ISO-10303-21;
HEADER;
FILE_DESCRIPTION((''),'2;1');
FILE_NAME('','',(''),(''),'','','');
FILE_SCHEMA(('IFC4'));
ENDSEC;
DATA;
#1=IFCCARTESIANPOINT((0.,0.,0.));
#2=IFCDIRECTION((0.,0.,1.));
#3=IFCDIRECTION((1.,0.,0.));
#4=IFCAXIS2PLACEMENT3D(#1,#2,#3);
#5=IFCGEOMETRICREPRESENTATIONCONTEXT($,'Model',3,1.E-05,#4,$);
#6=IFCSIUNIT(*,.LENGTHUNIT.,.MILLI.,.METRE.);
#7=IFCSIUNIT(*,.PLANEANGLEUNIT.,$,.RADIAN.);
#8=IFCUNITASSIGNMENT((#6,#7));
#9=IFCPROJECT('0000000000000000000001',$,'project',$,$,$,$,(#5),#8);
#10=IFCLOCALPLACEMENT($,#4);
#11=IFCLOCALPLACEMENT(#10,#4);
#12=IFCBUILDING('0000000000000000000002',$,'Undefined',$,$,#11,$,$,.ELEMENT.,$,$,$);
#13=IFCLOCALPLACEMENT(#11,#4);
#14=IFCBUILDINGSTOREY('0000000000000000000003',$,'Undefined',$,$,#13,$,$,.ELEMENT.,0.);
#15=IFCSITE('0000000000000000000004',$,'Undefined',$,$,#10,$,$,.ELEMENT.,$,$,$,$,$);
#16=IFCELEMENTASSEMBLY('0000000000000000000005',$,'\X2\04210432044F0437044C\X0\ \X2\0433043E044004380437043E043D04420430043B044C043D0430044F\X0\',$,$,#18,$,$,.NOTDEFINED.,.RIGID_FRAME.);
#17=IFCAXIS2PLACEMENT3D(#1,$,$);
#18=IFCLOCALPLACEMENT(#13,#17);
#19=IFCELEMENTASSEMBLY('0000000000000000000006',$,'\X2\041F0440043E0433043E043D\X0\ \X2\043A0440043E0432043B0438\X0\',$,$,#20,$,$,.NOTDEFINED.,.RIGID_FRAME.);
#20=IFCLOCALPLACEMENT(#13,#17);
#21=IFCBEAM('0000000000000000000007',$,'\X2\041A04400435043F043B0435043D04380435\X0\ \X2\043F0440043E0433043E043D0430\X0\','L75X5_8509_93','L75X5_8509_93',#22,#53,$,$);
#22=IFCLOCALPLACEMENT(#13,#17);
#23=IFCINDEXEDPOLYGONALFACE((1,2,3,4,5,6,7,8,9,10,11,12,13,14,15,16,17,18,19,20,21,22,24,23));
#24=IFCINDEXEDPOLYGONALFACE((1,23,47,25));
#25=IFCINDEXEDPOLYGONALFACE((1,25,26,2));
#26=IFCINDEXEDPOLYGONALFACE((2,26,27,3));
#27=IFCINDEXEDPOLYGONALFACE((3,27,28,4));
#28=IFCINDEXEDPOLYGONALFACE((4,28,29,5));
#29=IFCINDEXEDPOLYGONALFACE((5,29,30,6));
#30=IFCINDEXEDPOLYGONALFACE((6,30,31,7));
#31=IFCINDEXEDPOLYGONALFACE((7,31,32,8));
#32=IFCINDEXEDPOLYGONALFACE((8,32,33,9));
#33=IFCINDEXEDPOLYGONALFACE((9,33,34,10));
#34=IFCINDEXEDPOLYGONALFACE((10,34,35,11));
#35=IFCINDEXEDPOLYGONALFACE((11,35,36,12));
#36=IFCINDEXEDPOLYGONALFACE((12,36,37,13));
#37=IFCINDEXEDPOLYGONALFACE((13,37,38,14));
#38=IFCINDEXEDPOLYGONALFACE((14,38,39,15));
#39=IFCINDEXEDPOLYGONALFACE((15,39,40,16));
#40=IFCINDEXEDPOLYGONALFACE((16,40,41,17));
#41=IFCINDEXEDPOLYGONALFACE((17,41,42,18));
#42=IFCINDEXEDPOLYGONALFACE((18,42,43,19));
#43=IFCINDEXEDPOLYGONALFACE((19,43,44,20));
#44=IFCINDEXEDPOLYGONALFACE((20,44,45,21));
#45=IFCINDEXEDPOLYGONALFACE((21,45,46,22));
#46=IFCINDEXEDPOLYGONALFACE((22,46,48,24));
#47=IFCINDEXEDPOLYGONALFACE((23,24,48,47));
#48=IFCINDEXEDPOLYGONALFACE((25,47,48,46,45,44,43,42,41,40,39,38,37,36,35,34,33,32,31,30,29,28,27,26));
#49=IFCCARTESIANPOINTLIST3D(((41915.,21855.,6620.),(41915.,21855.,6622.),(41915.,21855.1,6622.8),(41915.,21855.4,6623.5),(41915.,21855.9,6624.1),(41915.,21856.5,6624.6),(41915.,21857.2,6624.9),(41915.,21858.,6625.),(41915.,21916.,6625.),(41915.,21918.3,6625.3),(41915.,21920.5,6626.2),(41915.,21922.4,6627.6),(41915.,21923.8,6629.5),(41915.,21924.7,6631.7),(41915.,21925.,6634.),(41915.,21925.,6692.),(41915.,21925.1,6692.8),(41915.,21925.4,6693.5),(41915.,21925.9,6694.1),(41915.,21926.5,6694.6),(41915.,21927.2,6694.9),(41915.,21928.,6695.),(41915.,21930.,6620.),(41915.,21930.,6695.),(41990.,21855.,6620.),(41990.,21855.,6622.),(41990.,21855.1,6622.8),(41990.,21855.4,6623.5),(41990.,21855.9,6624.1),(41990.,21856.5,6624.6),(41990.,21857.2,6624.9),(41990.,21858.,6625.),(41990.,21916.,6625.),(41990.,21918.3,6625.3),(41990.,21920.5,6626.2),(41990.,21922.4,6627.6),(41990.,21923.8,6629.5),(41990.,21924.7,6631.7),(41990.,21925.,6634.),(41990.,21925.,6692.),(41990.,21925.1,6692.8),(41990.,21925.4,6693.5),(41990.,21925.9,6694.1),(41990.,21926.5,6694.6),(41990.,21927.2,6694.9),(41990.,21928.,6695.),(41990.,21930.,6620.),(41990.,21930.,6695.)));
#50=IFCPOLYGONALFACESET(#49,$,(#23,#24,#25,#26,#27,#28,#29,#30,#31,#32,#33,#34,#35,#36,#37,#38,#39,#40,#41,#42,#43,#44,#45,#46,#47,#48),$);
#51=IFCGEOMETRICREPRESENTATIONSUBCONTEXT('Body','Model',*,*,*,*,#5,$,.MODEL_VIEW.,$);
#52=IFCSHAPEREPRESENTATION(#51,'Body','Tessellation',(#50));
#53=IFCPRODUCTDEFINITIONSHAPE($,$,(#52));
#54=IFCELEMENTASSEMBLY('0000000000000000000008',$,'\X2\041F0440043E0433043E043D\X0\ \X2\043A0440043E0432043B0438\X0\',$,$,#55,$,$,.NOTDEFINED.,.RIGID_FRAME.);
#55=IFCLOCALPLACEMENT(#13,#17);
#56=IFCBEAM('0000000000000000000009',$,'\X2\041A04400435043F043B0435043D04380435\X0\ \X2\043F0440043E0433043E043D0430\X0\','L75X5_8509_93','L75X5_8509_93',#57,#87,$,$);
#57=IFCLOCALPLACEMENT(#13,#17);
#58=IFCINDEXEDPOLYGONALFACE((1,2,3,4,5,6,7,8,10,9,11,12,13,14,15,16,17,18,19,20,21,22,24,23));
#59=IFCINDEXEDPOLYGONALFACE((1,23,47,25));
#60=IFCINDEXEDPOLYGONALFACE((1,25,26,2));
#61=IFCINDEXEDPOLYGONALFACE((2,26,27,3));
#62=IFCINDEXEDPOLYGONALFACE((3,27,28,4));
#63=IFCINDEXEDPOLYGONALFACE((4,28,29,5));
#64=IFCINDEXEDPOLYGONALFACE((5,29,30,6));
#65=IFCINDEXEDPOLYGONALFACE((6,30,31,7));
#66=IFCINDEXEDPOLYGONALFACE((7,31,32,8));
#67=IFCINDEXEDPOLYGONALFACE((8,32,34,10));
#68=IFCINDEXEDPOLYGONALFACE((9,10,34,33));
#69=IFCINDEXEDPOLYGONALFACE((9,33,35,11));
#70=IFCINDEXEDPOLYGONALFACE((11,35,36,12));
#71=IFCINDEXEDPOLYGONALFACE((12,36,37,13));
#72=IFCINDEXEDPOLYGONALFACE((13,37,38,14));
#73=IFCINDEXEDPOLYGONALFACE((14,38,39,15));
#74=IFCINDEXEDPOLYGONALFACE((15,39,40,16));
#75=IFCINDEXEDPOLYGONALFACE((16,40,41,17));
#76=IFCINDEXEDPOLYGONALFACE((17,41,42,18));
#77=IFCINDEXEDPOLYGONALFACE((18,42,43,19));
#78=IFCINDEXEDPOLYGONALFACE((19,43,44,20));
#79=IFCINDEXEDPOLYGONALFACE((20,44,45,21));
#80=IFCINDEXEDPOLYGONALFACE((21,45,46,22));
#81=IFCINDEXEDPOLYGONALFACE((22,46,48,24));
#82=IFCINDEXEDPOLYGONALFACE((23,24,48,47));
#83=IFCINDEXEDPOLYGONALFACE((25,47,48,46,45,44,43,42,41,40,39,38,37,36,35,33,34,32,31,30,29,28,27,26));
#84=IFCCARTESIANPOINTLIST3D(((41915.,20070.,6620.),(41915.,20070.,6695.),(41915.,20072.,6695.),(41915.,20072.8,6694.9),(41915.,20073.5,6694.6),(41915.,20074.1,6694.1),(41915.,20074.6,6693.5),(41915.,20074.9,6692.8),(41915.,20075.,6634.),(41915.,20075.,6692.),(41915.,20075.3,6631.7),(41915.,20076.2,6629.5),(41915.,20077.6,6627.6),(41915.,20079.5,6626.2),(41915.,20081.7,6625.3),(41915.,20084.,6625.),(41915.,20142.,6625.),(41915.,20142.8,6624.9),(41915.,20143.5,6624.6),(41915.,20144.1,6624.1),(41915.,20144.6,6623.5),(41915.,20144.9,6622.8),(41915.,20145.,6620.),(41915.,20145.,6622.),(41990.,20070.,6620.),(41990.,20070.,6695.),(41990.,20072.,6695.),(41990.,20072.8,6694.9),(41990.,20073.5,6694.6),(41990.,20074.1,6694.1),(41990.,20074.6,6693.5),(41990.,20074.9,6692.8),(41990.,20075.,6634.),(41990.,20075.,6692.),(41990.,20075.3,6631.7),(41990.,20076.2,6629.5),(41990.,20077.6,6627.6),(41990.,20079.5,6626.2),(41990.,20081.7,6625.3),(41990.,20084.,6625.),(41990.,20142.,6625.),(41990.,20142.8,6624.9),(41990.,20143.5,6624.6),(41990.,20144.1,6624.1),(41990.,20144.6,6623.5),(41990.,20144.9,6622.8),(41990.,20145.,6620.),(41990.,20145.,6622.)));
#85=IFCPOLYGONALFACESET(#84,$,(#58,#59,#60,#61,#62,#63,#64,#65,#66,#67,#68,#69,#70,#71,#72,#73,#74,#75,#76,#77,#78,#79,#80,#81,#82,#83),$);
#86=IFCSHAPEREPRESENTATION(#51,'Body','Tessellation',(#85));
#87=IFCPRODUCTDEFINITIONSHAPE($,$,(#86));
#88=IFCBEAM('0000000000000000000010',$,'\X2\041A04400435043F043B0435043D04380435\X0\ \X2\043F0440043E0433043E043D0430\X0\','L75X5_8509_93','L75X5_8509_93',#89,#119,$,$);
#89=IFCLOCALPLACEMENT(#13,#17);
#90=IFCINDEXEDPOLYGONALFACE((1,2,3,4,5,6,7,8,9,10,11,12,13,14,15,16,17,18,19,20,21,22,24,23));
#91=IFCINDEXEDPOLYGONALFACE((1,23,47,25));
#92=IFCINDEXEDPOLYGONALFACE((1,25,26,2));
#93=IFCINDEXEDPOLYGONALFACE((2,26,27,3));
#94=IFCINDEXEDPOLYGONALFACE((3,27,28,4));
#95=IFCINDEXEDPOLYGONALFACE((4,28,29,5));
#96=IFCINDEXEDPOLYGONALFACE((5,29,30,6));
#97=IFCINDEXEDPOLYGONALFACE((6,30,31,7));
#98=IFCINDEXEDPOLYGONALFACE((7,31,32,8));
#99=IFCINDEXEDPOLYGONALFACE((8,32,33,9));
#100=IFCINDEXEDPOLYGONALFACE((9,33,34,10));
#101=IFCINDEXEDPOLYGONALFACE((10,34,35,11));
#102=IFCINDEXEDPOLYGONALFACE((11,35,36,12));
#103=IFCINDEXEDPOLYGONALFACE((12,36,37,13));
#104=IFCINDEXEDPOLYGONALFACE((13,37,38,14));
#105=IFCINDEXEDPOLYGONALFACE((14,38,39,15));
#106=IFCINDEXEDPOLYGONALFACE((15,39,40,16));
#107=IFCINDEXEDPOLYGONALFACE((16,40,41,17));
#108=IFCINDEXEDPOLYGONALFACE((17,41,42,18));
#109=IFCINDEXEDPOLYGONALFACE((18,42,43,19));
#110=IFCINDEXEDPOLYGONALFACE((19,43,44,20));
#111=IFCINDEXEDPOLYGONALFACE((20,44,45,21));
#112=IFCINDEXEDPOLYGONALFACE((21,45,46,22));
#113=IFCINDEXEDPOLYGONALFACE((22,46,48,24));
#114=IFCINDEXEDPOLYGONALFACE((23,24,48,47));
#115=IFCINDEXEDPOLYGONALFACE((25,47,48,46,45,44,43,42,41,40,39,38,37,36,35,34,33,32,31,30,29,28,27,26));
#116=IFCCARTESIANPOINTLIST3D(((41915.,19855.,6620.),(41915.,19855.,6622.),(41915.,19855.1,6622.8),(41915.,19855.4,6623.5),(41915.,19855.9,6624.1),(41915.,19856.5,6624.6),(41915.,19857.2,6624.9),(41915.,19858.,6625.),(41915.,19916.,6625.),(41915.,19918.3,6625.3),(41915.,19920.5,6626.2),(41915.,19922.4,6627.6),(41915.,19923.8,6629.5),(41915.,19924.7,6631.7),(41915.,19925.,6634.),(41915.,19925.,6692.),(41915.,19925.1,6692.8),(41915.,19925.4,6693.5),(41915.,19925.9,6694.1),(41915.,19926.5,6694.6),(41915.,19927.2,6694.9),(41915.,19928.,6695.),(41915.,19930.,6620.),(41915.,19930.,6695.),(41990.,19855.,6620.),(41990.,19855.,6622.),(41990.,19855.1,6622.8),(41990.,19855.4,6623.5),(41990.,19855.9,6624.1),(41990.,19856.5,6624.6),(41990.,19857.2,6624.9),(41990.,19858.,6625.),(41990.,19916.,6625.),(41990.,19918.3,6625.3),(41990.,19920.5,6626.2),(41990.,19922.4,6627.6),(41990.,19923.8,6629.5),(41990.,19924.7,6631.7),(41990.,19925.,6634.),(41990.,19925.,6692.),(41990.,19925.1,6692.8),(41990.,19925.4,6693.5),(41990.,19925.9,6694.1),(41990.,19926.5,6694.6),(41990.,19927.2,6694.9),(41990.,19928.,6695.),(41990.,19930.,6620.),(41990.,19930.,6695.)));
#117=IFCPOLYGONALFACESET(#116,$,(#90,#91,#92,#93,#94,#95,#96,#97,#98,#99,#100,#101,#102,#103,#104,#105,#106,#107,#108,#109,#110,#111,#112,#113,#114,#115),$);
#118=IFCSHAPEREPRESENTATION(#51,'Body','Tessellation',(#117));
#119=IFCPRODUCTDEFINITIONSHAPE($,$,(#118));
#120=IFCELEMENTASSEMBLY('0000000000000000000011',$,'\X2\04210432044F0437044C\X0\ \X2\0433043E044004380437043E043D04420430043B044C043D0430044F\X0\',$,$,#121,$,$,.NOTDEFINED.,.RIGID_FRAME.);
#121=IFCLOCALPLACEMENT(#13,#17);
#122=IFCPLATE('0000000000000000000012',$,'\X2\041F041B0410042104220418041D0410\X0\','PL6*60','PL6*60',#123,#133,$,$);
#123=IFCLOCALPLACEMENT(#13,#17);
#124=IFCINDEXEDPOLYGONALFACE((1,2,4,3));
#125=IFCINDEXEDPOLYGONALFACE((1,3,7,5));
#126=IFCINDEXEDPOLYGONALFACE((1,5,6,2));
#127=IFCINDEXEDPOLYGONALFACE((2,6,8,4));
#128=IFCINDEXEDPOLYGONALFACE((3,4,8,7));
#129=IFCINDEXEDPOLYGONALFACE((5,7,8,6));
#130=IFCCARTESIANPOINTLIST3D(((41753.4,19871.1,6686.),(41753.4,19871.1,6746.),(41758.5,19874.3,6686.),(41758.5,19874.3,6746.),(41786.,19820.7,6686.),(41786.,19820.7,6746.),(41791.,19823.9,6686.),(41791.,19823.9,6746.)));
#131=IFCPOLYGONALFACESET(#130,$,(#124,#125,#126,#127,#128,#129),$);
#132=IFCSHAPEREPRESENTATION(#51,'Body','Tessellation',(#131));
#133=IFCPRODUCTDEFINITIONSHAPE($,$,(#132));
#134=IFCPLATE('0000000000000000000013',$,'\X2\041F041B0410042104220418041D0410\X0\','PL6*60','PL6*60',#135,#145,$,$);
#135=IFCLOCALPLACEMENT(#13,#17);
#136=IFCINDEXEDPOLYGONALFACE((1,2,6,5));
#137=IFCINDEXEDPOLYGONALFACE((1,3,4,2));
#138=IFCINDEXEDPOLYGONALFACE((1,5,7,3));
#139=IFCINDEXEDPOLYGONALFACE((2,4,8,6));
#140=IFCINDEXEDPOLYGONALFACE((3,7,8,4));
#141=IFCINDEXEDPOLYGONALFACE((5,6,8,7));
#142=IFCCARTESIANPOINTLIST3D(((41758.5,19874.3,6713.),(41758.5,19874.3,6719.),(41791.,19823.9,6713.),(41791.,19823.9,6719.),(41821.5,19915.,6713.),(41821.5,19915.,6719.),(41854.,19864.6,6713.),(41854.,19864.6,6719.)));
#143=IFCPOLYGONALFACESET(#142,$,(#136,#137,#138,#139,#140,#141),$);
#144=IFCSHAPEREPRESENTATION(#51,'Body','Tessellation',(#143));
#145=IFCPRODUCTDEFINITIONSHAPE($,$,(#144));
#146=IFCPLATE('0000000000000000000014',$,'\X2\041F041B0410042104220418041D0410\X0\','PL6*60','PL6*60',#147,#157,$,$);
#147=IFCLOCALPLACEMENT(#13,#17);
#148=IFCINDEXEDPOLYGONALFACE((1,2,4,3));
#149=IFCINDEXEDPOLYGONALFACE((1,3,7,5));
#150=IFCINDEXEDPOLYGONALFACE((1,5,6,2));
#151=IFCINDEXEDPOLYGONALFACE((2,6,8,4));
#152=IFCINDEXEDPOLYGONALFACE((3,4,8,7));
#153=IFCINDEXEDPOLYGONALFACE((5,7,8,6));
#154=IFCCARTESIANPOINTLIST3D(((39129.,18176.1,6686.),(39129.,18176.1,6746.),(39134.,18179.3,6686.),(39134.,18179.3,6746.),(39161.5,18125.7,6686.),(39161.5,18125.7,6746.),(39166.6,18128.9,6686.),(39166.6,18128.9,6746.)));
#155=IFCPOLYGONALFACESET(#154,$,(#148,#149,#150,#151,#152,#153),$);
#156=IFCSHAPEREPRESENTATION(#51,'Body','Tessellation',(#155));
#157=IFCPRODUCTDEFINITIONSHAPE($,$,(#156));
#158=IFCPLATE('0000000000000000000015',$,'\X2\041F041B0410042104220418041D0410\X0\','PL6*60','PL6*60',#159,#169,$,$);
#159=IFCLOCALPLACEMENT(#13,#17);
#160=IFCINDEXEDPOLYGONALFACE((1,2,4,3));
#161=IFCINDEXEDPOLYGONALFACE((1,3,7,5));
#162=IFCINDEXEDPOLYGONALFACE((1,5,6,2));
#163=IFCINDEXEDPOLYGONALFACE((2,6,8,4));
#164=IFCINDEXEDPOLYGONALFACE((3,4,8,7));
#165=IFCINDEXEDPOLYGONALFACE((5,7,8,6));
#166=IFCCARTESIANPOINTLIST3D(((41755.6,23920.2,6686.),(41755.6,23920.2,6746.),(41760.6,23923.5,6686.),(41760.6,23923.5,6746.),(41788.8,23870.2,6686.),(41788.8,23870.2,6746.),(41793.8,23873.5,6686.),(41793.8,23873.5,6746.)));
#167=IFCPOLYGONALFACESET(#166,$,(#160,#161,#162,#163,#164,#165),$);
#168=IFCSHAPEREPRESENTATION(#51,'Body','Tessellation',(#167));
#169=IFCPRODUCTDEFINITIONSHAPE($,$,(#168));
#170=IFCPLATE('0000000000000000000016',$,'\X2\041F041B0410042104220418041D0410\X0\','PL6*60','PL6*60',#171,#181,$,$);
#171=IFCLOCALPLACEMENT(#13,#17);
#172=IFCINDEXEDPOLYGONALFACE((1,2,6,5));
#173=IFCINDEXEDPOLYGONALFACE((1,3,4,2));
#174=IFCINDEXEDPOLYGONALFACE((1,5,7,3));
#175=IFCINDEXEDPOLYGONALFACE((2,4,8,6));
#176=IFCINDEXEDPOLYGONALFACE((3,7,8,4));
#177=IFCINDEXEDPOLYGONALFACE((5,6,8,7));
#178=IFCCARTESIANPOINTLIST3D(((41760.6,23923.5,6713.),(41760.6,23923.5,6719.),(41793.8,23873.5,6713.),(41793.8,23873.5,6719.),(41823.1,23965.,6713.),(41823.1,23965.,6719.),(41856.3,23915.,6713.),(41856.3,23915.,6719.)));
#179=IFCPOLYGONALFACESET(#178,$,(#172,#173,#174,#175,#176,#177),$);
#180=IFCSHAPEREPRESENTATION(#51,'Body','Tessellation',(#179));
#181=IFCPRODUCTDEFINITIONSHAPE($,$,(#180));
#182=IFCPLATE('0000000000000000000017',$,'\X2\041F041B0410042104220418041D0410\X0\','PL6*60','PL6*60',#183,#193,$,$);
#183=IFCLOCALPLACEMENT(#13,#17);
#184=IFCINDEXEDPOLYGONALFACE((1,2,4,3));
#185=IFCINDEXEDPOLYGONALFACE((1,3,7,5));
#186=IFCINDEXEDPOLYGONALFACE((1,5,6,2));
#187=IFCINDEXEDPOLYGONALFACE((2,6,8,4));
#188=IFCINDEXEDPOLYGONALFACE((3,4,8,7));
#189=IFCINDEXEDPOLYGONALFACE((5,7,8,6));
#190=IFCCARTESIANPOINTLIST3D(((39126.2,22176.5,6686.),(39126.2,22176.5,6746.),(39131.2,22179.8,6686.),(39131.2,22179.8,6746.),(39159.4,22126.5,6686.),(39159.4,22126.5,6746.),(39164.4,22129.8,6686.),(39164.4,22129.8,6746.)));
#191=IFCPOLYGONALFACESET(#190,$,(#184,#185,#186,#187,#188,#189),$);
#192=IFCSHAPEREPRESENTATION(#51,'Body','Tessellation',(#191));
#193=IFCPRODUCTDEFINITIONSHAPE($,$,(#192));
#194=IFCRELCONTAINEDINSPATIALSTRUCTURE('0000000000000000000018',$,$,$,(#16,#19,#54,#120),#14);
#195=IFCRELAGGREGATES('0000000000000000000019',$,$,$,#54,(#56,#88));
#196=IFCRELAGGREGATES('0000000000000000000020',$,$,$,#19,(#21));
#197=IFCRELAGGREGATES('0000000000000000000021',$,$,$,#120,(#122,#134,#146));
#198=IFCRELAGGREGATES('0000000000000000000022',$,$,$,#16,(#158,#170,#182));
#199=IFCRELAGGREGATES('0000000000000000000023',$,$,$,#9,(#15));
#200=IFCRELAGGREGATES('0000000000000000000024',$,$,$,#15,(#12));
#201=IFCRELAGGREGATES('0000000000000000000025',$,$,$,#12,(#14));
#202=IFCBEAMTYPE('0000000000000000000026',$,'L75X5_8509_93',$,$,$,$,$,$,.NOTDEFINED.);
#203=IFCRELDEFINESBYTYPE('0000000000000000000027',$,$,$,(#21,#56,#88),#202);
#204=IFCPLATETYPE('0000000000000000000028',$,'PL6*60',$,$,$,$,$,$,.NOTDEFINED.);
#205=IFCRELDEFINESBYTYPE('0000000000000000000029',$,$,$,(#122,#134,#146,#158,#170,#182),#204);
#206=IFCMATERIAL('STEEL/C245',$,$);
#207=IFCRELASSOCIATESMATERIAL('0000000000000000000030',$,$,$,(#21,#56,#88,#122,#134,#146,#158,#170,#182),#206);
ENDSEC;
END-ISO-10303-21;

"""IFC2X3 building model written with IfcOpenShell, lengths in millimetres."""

from ifc_helpers import new_model, si_unit, frame, origin_with_axes, origin_2d_with_axis, place, context, subcontext, project, spatial, polyline, l_section, outline, extrude, material, type_object, element, aggregate, save


model = new_model("IFC2X3")

# Units and contexts
model_context = context("Model", 3, precision=1e-05, world=origin_with_axes())
body_context = subcontext(model_context, "Body", "Model", "MODEL_VIEW")
ifc_project = project(units=[si_unit("LENGTHUNIT", "METRE", prefix="MILLI"), si_unit("PLANEANGLEUNIT", "RADIAN")], contexts=[model_context])

# Site, building, storey
site_placement = place(None, origin_with_axes())
site = spatial("IfcSite", under=ifc_project, at=site_placement, Name="Undefined", CompositionType="ELEMENT")
building_placement = place(site_placement, origin_with_axes())
building = spatial("IfcBuilding", under=site, at=building_placement, Name="Undefined", CompositionType="ELEMENT")
storey_placement = place(building_placement, origin_with_axes())
storey = spatial("IfcBuildingStorey", under=building, at=storey_placement, Name="Undefined", CompositionType="ELEMENT", Elevation=0.0)

# Element assembly
assembly_1_placement = place(storey_placement, origin_with_axes())
assembly_1 = element("IfcElementAssembly", 1, at=assembly_1_placement, inside=storey, Name="Связь горизонтальная", AssemblyPlace="NOTDEFINED", PredefinedType="RIGID_FRAME")
ifc_material_1 = material(Name="STEEL/C245")
beam_type_1 = type_object("IfcBeamType", Name="L75X5_8509_93", PredefinedType="NOTDEFINED")

# Element assemblies, beams
assembly_2_placement = place(storey_placement, origin_with_axes())
assembly_2 = element("IfcElementAssembly", 2, at=assembly_2_placement, inside=storey, Name="Прогон кровли", AssemblyPlace="NOTDEFINED", PredefinedType="RIGID_FRAME")
beam_1_placement = place(assembly_2_placement, frame((41990.0, 21892.5, 6657.5), z_axis=(0.0, -1.0, 0.0), x_axis=(-1.0, 0.0, 0.0)))
beam_1 = element("IfcBeam", 3, at=beam_1_placement, type_object=beam_type_1, material=ifc_material_1, Name="Крепление прогона", Description="L75X5_8509_93", ObjectType="L75X5_8509_93", context=body_context, shape_type="SweptSolid", body=[
    extrude(l_section(Depth=75.0, Width=75.0, Thickness=5.0, FilletRadius=9.0, EdgeRadius=3.0, at=origin_2d_with_axis()), frame((75.0, 0.0, 0.0), z_axis=(-1.0, 0.0, 0.0), x_axis=(0.0, -1.0, 0.0)), (0.0, 0.0, 1.0), 75.0),
])
assembly_3_placement = place(storey_placement, origin_with_axes())
assembly_3 = element("IfcElementAssembly", 4, at=assembly_3_placement, inside=storey, Name="Прогон кровли", AssemblyPlace="NOTDEFINED", PredefinedType="RIGID_FRAME")
beam_2_placement = place(assembly_3_placement, frame((41915.0, 20107.5, 6657.5), z_axis=(0.0, 1.0, 0.0), x_axis=(1.0, 0.0, 0.0)))
beam_2 = element("IfcBeam", 5, at=beam_2_placement, type_object=beam_type_1, material=ifc_material_1, Name="Крепление прогона", Description="L75X5_8509_93", ObjectType="L75X5_8509_93", context=body_context, shape_type="SweptSolid", body=[
    extrude(l_section(Depth=75.0, Width=75.0, Thickness=5.0, FilletRadius=9.0, EdgeRadius=3.0, at=origin_2d_with_axis()), frame((75.0, 0.0, 0.0), z_axis=(-1.0, 0.0, 0.0), x_axis=(0.0, -1.0, 0.0)), (0.0, 0.0, 1.0), 75.0),
])
beam_3_placement = place(assembly_3_placement, frame((41990.0, 19892.5, 6657.5), z_axis=(0.0, -1.0, 0.0), x_axis=(-1.0, 0.0, 0.0)))
beam_3 = element("IfcBeam", 6, at=beam_3_placement, type_object=beam_type_1, material=ifc_material_1, Name="Крепление прогона", Description="L75X5_8509_93", ObjectType="L75X5_8509_93", context=body_context, shape_type="SweptSolid", body=[
    extrude(l_section(Depth=75.0, Width=75.0, Thickness=5.0, FilletRadius=9.0, EdgeRadius=3.0, at=origin_2d_with_axis()), frame((75.0, 0.0, 0.0), z_axis=(-1.0, 0.0, 0.0), x_axis=(0.0, -1.0, 0.0)), (0.0, 0.0, 1.0), 75.0),
])

# Element assembly, plates
assembly_4_placement = place(storey_placement, origin_with_axes())
assembly_4 = element("IfcElementAssembly", 7, at=assembly_4_placement, inside=storey, Name="Связь горизонтальная", AssemblyPlace="NOTDEFINED", PredefinedType="RIGID_FRAME")
plate_type_1 = type_object("IfcPlateType", Name="PL6*60", PredefinedType="NOTDEFINED")
plate_1_placement = place(assembly_4_placement, frame((41772.2, 19847.5, 6686.0), z_axis=(0.840039, 0.542525, 0.0), x_axis=(0.0, 0.0, 1.0)))
plate_1 = element("IfcPlate", 8, at=plate_1_placement, type_object=plate_type_1, material=ifc_material_1, Name="ПЛАСТИНА", Description="PL6*60", ObjectType="PL6*60", context=body_context, shape_type="SweptSolid", body=[
    extrude(outline(polyline([(0.0, -30.0), (0.0, 30.0), (60.0, 30.0), (60.0, -30.0), (0.0, -30.0)])), frame((0.0, 0.0, -3.0), z_axis=(0.0, 0.0, 1.0), x_axis=(1.0, 0.0, 0.0)), (0.0, 0.0, 1.0), 6.0),
])
plate_2_placement = place(assembly_4_placement, frame((41837.8, 19889.8, 6716.0), z_axis=(0.0, 0.0, -1.0), x_axis=(-0.840039, -0.542525, 0.0)))
plate_2 = element("IfcPlate", 9, at=plate_2_placement, type_object=plate_type_1, material=ifc_material_1, Name="ПЛАСТИНА", Description="PL6*60", ObjectType="PL6*60", context=body_context, shape_type="SweptSolid", body=[
    extrude(outline(polyline([(75.0, 30.0), (75.0, -30.0), (0.0, -30.0), (0.0, 30.0), (75.0, 30.0)])), frame((0.0, 0.0, -3.0), z_axis=(0.0, 0.0, 1.0), x_axis=(1.0, 0.0, 0.0)), (0.0, 0.0, 1.0), 6.0),
])
plate_3_placement = place(assembly_4_placement, frame((39147.8, 18152.5, 6686.0), z_axis=(-0.840039, -0.542525, 0.0), x_axis=(0.0, 0.0, 1.0)))
plate_3 = element("IfcPlate", 10, at=plate_3_placement, type_object=plate_type_1, material=ifc_material_1, Name="ПЛАСТИНА", Description="PL6*60", ObjectType="PL6*60", context=body_context, shape_type="SweptSolid", body=[
    extrude(outline(polyline([(0.0, 30.0), (60.0, 30.0), (60.0, -30.0), (0.0, -30.0), (0.0, 30.0)])), frame((0.0, 0.0, -3.0), z_axis=(0.0, 0.0, 1.0), x_axis=(1.0, 0.0, 0.0)), (0.0, 0.0, 1.0), 6.0),
])

# Plates
plate_4_placement = place(assembly_1_placement, frame((41774.7, 23896.9, 6686.0), z_axis=(0.833383, 0.552695, 0.0), x_axis=(0.0, 0.0, 1.0)))
plate_4 = element("IfcPlate", 11, at=plate_4_placement, type_object=plate_type_1, material=ifc_material_1, Name="ПЛАСТИНА", Description="PL6*60", ObjectType="PL6*60", context=body_context, shape_type="SweptSolid", body=[
    extrude(outline(polyline([(0.0, -30.0), (0.0, 30.0), (60.0, 30.0), (60.0, -30.0), (0.0, -30.0)])), frame((0.0, 0.0, -3.0), z_axis=(0.0, 0.0, 1.0), x_axis=(1.0, 0.0, 0.0)), (0.0, 0.0, 1.0), 6.0),
])
plate_5_placement = place(assembly_1_placement, frame((41839.7, 23940.0, 6716.0), z_axis=(0.0, 0.0, -1.0), x_axis=(-0.833383, -0.552695, 0.0)))
plate_5 = element("IfcPlate", 12, at=plate_5_placement, type_object=plate_type_1, material=ifc_material_1, Name="ПЛАСТИНА", Description="PL6*60", ObjectType="PL6*60", context=body_context, shape_type="SweptSolid", body=[
    extrude(outline(polyline([(75.0, 30.0), (75.0, -30.0), (0.0, -30.0), (0.0, 30.0), (75.0, 30.0)])), frame((0.0, 0.0, -3.0), z_axis=(0.0, 0.0, 1.0), x_axis=(1.0, 0.0, 0.0)), (0.0, 0.0, 1.0), 6.0),
])
plate_6_placement = place(assembly_1_placement, frame((39145.3, 22153.1, 6686.0), z_axis=(-0.833383, -0.552695, 0.0), x_axis=(0.0, 0.0, 1.0)))
plate_6 = element("IfcPlate", 13, at=plate_6_placement, type_object=plate_type_1, material=ifc_material_1, Name="ПЛАСТИНА", Description="PL6*60", ObjectType="PL6*60", context=body_context, shape_type="SweptSolid", body=[
    extrude(outline(polyline([(0.0, 30.0), (60.0, 30.0), (60.0, -30.0), (0.0, -30.0), (0.0, 30.0)])), frame((0.0, 0.0, -3.0), z_axis=(0.0, 0.0, 1.0), x_axis=(1.0, 0.0, 0.0)), (0.0, 0.0, 1.0), 6.0),
])
aggregate(assembly_3, [beam_2, beam_3])
aggregate(assembly_2, [beam_1])

aggregate(assembly_4, [plate_1, plate_2, plate_3])
aggregate(assembly_1, [plate_4, plate_5, plate_6])

save(model, "model.ifc")
